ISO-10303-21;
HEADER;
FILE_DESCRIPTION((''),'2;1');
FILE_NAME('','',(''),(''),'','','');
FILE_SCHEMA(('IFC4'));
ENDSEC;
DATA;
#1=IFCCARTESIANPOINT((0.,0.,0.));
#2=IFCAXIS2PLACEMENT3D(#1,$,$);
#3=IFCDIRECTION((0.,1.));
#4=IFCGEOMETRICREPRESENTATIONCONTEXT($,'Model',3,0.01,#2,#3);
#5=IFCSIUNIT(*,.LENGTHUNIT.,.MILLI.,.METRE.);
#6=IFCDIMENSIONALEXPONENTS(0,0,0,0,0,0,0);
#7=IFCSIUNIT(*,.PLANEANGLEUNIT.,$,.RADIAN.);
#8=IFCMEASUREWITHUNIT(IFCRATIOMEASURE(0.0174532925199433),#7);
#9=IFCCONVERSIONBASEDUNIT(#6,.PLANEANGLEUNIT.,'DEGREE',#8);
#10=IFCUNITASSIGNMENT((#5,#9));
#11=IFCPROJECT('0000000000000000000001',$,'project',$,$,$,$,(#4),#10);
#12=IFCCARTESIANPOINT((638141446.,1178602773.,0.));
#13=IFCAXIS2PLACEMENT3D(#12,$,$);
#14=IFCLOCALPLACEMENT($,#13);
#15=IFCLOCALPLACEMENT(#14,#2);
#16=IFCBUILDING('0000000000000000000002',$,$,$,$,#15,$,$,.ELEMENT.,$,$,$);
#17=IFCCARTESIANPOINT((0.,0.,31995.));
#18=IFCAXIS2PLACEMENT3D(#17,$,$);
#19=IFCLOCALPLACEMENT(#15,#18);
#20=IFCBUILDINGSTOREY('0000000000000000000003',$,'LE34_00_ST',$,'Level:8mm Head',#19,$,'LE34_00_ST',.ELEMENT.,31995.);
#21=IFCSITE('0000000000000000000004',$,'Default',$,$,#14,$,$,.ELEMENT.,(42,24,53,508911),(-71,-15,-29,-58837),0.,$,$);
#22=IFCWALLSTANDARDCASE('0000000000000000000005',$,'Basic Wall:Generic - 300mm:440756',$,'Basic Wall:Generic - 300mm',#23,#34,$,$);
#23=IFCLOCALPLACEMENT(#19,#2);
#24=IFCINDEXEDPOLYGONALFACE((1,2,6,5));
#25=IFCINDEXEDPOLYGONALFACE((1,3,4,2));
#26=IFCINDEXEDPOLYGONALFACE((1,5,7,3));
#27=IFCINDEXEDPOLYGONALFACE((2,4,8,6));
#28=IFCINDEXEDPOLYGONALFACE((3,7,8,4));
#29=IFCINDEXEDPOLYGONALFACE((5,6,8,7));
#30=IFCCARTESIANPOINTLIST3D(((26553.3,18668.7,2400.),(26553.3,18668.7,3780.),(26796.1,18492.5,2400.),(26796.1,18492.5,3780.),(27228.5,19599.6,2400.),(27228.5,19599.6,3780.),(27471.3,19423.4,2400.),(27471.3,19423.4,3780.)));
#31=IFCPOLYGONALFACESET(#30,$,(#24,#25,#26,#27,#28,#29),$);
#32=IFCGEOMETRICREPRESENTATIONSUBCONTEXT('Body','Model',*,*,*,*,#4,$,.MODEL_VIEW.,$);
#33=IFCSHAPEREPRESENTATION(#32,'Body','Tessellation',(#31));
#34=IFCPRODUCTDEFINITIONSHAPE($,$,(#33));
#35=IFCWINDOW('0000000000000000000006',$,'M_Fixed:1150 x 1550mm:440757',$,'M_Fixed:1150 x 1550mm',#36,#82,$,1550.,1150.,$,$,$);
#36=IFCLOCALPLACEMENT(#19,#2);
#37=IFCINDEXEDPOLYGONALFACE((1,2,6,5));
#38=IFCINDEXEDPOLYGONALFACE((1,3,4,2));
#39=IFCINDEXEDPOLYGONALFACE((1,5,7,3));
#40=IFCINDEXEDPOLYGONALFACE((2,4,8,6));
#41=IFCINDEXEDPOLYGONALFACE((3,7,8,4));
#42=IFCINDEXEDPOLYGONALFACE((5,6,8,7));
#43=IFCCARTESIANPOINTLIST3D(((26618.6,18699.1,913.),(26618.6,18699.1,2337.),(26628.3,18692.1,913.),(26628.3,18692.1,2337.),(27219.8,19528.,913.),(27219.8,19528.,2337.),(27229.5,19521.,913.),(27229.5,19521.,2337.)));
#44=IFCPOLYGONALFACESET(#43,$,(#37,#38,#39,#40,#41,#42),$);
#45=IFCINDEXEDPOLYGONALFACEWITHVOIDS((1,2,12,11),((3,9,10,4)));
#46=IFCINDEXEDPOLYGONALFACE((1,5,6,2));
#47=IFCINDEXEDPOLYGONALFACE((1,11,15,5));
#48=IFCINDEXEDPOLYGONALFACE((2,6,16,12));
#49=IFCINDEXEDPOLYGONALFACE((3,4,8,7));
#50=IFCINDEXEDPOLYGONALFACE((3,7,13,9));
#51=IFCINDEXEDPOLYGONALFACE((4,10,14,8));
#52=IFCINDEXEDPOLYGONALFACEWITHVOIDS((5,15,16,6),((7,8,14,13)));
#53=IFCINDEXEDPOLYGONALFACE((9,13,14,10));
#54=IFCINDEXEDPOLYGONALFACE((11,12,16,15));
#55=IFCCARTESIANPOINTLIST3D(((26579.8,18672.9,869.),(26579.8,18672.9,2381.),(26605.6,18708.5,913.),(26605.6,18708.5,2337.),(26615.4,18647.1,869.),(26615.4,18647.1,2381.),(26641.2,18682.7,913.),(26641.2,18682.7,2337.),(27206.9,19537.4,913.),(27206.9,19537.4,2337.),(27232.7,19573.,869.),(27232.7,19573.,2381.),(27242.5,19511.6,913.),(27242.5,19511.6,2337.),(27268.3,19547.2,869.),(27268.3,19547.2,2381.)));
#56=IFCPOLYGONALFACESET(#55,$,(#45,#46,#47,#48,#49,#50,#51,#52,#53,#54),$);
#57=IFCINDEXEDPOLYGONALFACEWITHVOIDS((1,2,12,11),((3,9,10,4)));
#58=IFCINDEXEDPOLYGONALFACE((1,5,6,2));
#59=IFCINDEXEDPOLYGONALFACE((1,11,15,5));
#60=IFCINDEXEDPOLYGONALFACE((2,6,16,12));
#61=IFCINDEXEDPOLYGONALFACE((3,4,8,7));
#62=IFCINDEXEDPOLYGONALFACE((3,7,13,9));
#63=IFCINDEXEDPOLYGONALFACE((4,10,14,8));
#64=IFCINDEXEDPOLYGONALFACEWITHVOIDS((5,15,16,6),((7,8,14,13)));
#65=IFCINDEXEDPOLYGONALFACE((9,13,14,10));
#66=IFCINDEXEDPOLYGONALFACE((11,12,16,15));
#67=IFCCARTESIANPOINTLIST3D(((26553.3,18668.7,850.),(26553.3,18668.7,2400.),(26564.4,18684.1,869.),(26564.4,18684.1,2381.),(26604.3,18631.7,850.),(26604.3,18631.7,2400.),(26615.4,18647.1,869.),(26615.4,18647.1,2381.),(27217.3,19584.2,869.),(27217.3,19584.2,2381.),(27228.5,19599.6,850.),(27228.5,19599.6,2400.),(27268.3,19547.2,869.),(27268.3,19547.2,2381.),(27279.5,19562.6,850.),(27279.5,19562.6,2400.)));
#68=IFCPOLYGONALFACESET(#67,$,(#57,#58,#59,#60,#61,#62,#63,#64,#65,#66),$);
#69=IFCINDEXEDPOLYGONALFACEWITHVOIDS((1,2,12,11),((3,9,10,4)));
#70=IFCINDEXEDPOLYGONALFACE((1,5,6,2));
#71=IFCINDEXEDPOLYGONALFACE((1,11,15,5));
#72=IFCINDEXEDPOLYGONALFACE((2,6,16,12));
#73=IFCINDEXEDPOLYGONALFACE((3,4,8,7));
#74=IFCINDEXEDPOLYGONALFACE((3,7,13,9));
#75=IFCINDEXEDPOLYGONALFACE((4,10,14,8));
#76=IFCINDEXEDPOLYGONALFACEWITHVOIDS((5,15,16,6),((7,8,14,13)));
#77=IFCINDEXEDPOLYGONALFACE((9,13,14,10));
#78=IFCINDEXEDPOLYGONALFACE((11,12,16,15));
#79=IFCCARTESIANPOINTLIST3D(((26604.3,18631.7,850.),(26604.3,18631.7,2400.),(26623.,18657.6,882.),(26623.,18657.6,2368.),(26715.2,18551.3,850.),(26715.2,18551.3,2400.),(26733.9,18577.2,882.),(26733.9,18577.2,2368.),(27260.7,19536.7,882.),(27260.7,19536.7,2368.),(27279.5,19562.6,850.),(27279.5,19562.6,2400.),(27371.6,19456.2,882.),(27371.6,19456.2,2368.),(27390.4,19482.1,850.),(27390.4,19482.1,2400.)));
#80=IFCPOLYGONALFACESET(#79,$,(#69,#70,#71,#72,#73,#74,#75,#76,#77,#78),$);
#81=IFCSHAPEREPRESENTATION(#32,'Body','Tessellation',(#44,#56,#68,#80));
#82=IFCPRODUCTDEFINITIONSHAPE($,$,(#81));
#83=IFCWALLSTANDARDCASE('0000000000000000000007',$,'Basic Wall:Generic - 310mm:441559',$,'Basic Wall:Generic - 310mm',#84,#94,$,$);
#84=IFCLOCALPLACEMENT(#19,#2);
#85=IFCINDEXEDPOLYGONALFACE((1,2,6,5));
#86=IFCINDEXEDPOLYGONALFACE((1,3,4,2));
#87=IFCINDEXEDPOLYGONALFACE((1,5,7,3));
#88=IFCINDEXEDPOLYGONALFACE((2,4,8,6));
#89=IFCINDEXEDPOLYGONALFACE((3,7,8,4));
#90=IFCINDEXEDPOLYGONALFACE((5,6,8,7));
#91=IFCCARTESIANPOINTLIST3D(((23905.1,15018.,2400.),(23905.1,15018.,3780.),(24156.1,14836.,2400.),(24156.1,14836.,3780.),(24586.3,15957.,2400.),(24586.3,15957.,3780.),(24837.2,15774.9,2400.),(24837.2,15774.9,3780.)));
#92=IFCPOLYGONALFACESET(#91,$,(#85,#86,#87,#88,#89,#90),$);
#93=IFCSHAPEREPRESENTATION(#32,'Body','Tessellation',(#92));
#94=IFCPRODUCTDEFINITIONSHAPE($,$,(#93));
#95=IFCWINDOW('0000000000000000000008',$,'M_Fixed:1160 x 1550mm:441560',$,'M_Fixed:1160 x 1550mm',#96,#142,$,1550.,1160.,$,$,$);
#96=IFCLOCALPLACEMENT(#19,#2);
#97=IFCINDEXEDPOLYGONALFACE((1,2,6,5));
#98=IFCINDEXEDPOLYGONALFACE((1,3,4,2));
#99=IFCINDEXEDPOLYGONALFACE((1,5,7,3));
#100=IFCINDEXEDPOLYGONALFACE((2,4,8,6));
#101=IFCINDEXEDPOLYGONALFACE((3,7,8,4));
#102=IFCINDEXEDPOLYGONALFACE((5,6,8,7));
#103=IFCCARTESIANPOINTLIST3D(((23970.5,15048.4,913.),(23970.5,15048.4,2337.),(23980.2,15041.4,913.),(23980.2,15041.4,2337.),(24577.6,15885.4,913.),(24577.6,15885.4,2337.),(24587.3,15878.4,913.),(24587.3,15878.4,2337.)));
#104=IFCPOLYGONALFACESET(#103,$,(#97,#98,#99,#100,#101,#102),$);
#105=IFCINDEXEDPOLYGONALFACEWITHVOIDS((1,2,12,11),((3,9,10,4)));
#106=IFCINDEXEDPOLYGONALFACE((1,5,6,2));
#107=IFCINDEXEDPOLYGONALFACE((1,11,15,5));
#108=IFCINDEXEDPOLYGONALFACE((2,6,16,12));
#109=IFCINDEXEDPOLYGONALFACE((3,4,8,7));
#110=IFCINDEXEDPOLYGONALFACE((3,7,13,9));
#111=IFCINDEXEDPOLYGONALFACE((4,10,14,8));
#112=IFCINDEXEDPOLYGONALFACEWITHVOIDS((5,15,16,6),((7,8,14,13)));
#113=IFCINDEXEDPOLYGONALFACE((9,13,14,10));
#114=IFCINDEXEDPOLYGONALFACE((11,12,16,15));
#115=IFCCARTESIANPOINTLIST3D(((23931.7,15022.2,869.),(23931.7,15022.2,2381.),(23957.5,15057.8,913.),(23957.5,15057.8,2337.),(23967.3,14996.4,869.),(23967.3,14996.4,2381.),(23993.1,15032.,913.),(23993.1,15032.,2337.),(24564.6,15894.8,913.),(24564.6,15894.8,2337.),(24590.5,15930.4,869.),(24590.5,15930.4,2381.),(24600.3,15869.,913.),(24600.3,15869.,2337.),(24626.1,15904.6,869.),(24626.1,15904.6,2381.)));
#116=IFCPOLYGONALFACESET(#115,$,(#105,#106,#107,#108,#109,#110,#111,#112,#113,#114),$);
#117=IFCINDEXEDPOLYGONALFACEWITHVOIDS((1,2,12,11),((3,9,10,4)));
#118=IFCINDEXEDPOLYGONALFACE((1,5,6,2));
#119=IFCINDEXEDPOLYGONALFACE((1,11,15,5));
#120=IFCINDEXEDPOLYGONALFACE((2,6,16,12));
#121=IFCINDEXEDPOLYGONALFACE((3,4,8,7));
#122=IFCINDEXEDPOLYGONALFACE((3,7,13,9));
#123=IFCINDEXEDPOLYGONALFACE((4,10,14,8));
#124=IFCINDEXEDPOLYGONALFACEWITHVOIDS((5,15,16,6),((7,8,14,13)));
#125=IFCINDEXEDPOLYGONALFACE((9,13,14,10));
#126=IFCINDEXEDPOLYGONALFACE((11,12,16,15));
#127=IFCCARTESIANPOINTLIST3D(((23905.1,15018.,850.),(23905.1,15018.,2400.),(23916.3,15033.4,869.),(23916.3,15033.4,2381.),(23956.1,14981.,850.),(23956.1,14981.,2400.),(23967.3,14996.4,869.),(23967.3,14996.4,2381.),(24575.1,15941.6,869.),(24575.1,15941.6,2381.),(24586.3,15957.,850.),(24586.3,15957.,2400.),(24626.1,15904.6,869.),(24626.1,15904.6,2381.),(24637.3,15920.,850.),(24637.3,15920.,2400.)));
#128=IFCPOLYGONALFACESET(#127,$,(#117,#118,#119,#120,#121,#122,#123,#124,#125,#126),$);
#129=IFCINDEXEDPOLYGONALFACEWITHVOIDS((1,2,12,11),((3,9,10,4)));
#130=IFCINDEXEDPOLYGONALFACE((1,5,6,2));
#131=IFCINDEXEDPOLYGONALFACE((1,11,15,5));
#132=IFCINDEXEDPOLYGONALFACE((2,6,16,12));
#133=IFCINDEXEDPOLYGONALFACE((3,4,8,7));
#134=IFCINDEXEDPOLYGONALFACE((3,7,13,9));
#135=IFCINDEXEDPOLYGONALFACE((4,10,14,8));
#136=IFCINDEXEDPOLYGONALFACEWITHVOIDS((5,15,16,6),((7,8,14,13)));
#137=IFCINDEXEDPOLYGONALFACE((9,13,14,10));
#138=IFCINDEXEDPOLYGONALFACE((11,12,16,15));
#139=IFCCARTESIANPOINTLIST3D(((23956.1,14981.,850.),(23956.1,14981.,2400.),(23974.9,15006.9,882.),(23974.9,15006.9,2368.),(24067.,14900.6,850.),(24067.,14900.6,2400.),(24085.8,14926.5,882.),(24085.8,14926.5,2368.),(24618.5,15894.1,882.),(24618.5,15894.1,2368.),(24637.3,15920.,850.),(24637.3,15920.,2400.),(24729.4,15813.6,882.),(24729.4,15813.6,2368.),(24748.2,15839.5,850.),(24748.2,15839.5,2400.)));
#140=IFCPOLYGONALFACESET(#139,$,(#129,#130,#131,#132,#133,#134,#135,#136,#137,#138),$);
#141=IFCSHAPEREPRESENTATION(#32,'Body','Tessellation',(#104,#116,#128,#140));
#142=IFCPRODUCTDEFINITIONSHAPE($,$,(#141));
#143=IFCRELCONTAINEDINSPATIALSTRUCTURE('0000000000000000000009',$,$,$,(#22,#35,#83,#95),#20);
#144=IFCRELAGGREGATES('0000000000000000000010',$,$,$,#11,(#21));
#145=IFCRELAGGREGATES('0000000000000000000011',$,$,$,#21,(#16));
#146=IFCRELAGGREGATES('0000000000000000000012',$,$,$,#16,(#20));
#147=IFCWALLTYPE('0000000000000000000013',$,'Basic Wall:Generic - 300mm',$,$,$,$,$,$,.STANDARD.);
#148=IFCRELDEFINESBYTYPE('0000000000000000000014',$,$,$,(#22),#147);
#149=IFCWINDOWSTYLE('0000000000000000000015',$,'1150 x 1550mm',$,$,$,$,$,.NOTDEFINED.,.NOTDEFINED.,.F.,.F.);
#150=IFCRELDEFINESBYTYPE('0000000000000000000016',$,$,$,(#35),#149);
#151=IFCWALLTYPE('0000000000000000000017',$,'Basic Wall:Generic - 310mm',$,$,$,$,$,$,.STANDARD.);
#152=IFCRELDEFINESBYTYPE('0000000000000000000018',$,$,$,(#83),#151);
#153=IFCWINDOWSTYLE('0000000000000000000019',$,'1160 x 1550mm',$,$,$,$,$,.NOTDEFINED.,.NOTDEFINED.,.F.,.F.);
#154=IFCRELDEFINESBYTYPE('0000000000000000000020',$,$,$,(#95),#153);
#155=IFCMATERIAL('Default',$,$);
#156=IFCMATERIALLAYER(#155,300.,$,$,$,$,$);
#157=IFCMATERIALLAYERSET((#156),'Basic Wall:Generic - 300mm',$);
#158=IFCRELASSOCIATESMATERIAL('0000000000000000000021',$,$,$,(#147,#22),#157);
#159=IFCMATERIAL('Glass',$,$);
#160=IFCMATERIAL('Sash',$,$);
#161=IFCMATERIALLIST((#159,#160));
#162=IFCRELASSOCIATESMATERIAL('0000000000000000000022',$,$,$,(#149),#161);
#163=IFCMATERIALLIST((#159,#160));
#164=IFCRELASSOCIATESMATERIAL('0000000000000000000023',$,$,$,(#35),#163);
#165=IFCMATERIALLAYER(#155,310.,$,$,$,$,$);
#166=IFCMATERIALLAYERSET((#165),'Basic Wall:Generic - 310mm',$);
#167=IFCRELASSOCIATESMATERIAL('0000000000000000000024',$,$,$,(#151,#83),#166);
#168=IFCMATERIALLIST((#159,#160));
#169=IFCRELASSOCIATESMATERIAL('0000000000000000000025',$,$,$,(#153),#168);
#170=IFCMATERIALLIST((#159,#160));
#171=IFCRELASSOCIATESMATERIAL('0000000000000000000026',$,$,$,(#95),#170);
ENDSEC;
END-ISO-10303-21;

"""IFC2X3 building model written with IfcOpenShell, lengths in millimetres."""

from ifc_helpers import new_model, entity, si_unit, converted_unit, direction, frame, frame_2d, origin, place, context, subcontext, project, spatial, polyline, rectangle, outline, extrude, source, transform, mapped, material, material_list, layer, layer_set, layer_usage, type_object, type_shapes, element, fill, save


model = new_model("IFC2X3")

# Units and contexts
model_context = context("Model", 3, precision=0.01, world=origin(), true_north=direction((0.0, 1.0)))
body_context = subcontext(model_context, "Body", "Model", "MODEL_VIEW")
ifc_project = project(units=[si_unit("LENGTHUNIT", "METRE", prefix="MILLI"), converted_unit("PLANEANGLEUNIT", "DEGREE", entity("IfcRatioMeasure", 0.0174532925199433), si_unit("PLANEANGLEUNIT", "RADIAN"), dimensions=[0, 0, 0, 0, 0, 0, 0])], contexts=[model_context])

# Site, building, storey
site_placement = place(None, frame((638141446.0, 1178602773.0, 0.0)))
site = spatial("IfcSite", under=ifc_project, at=site_placement, Name="Default", CompositionType="ELEMENT", RefLatitude=(42, 24, 53, 508911), RefLongitude=(-71, -15, -29, -58837), RefElevation=0.0)
building_placement = place(site_placement, origin())
building = spatial("IfcBuilding", under=site, at=building_placement, CompositionType="ELEMENT")
storey_placement = place(building_placement, frame((0.0, 0.0, 31995.0)))
storey = spatial("IfcBuildingStorey", under=building, at=storey_placement, Name="LE34_00_ST", ObjectType="Level:8mm Head", LongName="LE34_00_ST", CompositionType="ELEMENT", Elevation=31995.0)

# Walls, openings, windows
ifc_material_1 = material(Name="Default")
ifc_layer_1 = layer(ifc_material_1, 300.0)
ifc_layer_set_1 = layer_set([ifc_layer_1], Name="Basic Wall:Generic - 300mm")
wall_type_1 = type_object("IfcWallType", Name="Basic Wall:Generic - 300mm", PredefinedType="STANDARD", material=ifc_layer_set_1)
ifc_material_2 = material(Name="Glass")
ifc_material_3 = material(Name="Sash")
ifc_material_list_1 = material_list([ifc_material_2, ifc_material_3])
window_style_1 = type_object("IfcWindowStyle", Name="1150 x 1550mm", ConstructionType="NOTDEFINED", OperationType="NOTDEFINED", ParameterTakesPrecedence=False, Sizeable=False, material=ifc_material_list_1)
shared_shape_1 = source(origin(), body_context, "Body", "SweptSolid", [
    extrude(rectangle(XDim=12.0, YDim=1024.0, at=frame_2d((0.0, 0.0), x_axis=(1.0, 0.0))), frame((575.0, 259.0, 63.0), z_axis=(0.0, 0.0, 1.0), x_axis=(0.0, -1.0, 0.0)), (0.0, 0.0, 1.0), 1424.0),
    extrude(outline(polyline([(-556.0, -756.0), (556.0, -756.0), (556.0, 756.0), (-556.0, 756.0), (-556.0, -756.0)]), holes=[polyline([(-512.0, -712.0), (-512.0, 712.0), (512.0, 712.0), (512.0, -712.0), (-512.0, -712.0)])]), frame((575.0, 237.0, 775.0), z_axis=(0.0, 1.0, 0.0), x_axis=(1.0, 0.0, 0.0)), (0.0, 0.0, 1.0), 44.0),
    extrude(outline(polyline([(-575.0, -775.0), (575.0, -775.0), (575.0, 775.0), (-575.0, 775.0), (-575.0, -775.0)]), holes=[polyline([(-556.0, -756.0), (-556.0, 756.0), (556.0, 756.0), (556.0, -756.0), (-556.0, -756.0)])]), frame((575.0, 237.0, 775.0), z_axis=(0.0, 1.0, 0.0), x_axis=(1.0, 0.0, 0.0)), (0.0, 0.0, 1.0), 63.0),
    extrude(outline(polyline([(-575.0, -775.0), (575.0, -775.0), (575.0, 775.0), (-575.0, 775.0), (-575.0, -775.0)]), holes=[polyline([(-543.0, -743.0), (-543.0, 743.0), (543.0, 743.0), (543.0, -743.0), (-543.0, -743.0)])]), frame((575.0, 100.0, 775.0), z_axis=(0.0, 1.0, 0.0), x_axis=(1.0, 0.0, 0.0)), (0.0, 0.0, 1.0), 137.0),
])
type_shapes(window_style_1, [shared_shape_1])
ifc_layer_usage_1 = layer_usage(ifc_layer_set_1, "AXIS2", "NEGATIVE", 150.0)
wall_1_placement = place(storey_placement, frame((26674.7, 18580.6, 2400.0), z_axis=(0.0, 0.0, 1.0), x_axis=(0.587164, 0.809468, 0.0)))
wall_1 = element("IfcWallStandardCase", 1, at=wall_1_placement, inside=storey, type_object=wall_type_1, material=ifc_layer_usage_1, Name="Basic Wall:Generic - 300mm:440756", ObjectType="Basic Wall:Generic - 300mm", context=body_context, shape_type="SweptSolid", body=[
    extrude(rectangle(XDim=1150.0, YDim=300.0, at=frame_2d((575.0, 0.0), x_axis=(-1.0, 0.0))), origin(), (0.0, 0.0, 1.0), 1380.0),
])
opening_1_placement = place(wall_1_placement, frame((0.0, -150.0, -1550.0)))
opening_1 = element("IfcOpeningElement", 2, at=opening_1_placement, cuts=wall_1, ObjectType="Opening", context=body_context, shape_type="SweptSolid", body=[
    extrude(rectangle(XDim=1550.0, YDim=1150.0, at=frame_2d((775.0, 575.0), x_axis=(1.0, 0.0))), frame((0.0, 0.0, 0.0), z_axis=(0.0, 1.0, 0.0), x_axis=(0.0, 0.0, 1.0)), (0.0, 0.0, 1.0), 300.0),
])
ifc_material_list_2 = material_list([ifc_material_2, ifc_material_3])
window_1_placement = place(opening_1_placement, origin())
window_1 = element("IfcWindow", 3, at=window_1_placement, inside=storey, type_object=window_style_1, material=ifc_material_list_2, Name="M_Fixed:1150 x 1550mm:440757", ObjectType="M_Fixed:1150 x 1550mm", OverallHeight=1550.0, OverallWidth=1150.0, context=body_context, shape_type="MappedRepresentation", body=[
    mapped(shared_shape_1, transform((0.0, 0.0, 0.0), scale=1.0)),
])
fill(opening_1, window_1)
ifc_layer_2 = layer(ifc_material_1, 310.0)
ifc_layer_set_2 = layer_set([ifc_layer_2], Name="Basic Wall:Generic - 310mm")
ifc_layer_usage_2 = layer_usage(ifc_layer_set_2, "AXIS2", "NEGATIVE", 155.0)
wall_type_2 = type_object("IfcWallType", Name="Basic Wall:Generic - 310mm", PredefinedType="STANDARD", material=ifc_layer_set_2)
wall_2_placement = place(storey_placement, frame((24030.6, 14927.0, 2400.0), z_axis=(0.0, 0.0, 1.0), x_axis=(0.587164, 0.809468, 0.0)))
wall_2 = element("IfcWallStandardCase", 4, at=wall_2_placement, inside=storey, type_object=wall_type_2, material=ifc_layer_usage_2, Name="Basic Wall:Generic - 310mm:441559", ObjectType="Basic Wall:Generic - 310mm", context=body_context, shape_type="SweptSolid", body=[
    extrude(rectangle(XDim=1160.0, YDim=310.0, at=frame_2d((580.0, 0.0), x_axis=(-1.0, 0.0))), origin(), (0.0, 0.0, 1.0), 1380.0),
])
opening_2_placement = place(wall_2_placement, frame((0.0, -155.0, -1550.0)))
opening_2 = element("IfcOpeningElement", 5, at=opening_2_placement, cuts=wall_2, ObjectType="Opening", context=body_context, shape_type="SweptSolid", body=[
    extrude(rectangle(XDim=1550.0, YDim=1160.0, at=frame_2d((775.0, 580.0), x_axis=(1.0, 0.0))), frame((0.0, 0.0, 0.0), z_axis=(0.0, 1.0, 0.0), x_axis=(0.0, 0.0, 1.0)), (0.0, 0.0, 1.0), 310.0),
])
ifc_material_list_3 = material_list([ifc_material_2, ifc_material_3])
ifc_material_list_4 = material_list([ifc_material_2, ifc_material_3])
window_style_2 = type_object("IfcWindowStyle", Name="1160 x 1550mm", ConstructionType="NOTDEFINED", OperationType="NOTDEFINED", ParameterTakesPrecedence=False, Sizeable=False, material=ifc_material_list_4)
shared_shape_2 = source(origin(), body_context, "Body", "SweptSolid", [
    extrude(rectangle(XDim=12.0, YDim=1034.0, at=frame_2d((0.0, 0.0), x_axis=(1.0, 0.0))), frame((580.0, 269.0, 63.0), z_axis=(0.0, 0.0, 1.0), x_axis=(0.0, -1.0, 0.0)), (0.0, 0.0, 1.0), 1424.0),
    extrude(outline(polyline([(-561.0, -756.0), (561.0, -756.0), (561.0, 756.0), (-561.0, 756.0), (-561.0, -756.0)]), holes=[polyline([(-517.0, -712.0), (-517.0, 712.0), (517.0, 712.0), (517.0, -712.0), (-517.0, -712.0)])]), frame((580.0, 247.0, 775.0), z_axis=(0.0, 1.0, 0.0), x_axis=(1.0, 0.0, 0.0)), (0.0, 0.0, 1.0), 44.0),
    extrude(outline(polyline([(-580.0, -775.0), (580.0, -775.0), (580.0, 775.0), (-580.0, 775.0), (-580.0, -775.0)]), holes=[polyline([(-561.0, -756.0), (-561.0, 756.0), (561.0, 756.0), (561.0, -756.0), (-561.0, -756.0)])]), frame((580.0, 247.0, 775.0), z_axis=(0.0, 1.0, 0.0), x_axis=(1.0, 0.0, 0.0)), (0.0, 0.0, 1.0), 63.0),
    extrude(outline(polyline([(-580.0, -775.0), (580.0, -775.0), (580.0, 775.0), (-580.0, 775.0), (-580.0, -775.0)]), holes=[polyline([(-548.0, -743.0), (-548.0, 743.0), (548.0, 743.0), (548.0, -743.0), (-548.0, -743.0)])]), frame((580.0, 110.0, 775.0), z_axis=(0.0, 1.0, 0.0), x_axis=(1.0, 0.0, 0.0)), (0.0, 0.0, 1.0), 137.0),
])
type_shapes(window_style_2, [shared_shape_2])
window_2_placement = place(opening_2_placement, origin())
window_2 = element("IfcWindow", 6, at=window_2_placement, inside=storey, type_object=window_style_2, material=ifc_material_list_3, Name="M_Fixed:1160 x 1550mm:441560", ObjectType="M_Fixed:1160 x 1550mm", OverallHeight=1550.0, OverallWidth=1160.0, context=body_context, shape_type="MappedRepresentation", body=[
    mapped(shared_shape_2, transform((0.0, 0.0, 0.0), scale=1.0)),
])
fill(opening_2, window_2)

save(model, "model.ifc")
